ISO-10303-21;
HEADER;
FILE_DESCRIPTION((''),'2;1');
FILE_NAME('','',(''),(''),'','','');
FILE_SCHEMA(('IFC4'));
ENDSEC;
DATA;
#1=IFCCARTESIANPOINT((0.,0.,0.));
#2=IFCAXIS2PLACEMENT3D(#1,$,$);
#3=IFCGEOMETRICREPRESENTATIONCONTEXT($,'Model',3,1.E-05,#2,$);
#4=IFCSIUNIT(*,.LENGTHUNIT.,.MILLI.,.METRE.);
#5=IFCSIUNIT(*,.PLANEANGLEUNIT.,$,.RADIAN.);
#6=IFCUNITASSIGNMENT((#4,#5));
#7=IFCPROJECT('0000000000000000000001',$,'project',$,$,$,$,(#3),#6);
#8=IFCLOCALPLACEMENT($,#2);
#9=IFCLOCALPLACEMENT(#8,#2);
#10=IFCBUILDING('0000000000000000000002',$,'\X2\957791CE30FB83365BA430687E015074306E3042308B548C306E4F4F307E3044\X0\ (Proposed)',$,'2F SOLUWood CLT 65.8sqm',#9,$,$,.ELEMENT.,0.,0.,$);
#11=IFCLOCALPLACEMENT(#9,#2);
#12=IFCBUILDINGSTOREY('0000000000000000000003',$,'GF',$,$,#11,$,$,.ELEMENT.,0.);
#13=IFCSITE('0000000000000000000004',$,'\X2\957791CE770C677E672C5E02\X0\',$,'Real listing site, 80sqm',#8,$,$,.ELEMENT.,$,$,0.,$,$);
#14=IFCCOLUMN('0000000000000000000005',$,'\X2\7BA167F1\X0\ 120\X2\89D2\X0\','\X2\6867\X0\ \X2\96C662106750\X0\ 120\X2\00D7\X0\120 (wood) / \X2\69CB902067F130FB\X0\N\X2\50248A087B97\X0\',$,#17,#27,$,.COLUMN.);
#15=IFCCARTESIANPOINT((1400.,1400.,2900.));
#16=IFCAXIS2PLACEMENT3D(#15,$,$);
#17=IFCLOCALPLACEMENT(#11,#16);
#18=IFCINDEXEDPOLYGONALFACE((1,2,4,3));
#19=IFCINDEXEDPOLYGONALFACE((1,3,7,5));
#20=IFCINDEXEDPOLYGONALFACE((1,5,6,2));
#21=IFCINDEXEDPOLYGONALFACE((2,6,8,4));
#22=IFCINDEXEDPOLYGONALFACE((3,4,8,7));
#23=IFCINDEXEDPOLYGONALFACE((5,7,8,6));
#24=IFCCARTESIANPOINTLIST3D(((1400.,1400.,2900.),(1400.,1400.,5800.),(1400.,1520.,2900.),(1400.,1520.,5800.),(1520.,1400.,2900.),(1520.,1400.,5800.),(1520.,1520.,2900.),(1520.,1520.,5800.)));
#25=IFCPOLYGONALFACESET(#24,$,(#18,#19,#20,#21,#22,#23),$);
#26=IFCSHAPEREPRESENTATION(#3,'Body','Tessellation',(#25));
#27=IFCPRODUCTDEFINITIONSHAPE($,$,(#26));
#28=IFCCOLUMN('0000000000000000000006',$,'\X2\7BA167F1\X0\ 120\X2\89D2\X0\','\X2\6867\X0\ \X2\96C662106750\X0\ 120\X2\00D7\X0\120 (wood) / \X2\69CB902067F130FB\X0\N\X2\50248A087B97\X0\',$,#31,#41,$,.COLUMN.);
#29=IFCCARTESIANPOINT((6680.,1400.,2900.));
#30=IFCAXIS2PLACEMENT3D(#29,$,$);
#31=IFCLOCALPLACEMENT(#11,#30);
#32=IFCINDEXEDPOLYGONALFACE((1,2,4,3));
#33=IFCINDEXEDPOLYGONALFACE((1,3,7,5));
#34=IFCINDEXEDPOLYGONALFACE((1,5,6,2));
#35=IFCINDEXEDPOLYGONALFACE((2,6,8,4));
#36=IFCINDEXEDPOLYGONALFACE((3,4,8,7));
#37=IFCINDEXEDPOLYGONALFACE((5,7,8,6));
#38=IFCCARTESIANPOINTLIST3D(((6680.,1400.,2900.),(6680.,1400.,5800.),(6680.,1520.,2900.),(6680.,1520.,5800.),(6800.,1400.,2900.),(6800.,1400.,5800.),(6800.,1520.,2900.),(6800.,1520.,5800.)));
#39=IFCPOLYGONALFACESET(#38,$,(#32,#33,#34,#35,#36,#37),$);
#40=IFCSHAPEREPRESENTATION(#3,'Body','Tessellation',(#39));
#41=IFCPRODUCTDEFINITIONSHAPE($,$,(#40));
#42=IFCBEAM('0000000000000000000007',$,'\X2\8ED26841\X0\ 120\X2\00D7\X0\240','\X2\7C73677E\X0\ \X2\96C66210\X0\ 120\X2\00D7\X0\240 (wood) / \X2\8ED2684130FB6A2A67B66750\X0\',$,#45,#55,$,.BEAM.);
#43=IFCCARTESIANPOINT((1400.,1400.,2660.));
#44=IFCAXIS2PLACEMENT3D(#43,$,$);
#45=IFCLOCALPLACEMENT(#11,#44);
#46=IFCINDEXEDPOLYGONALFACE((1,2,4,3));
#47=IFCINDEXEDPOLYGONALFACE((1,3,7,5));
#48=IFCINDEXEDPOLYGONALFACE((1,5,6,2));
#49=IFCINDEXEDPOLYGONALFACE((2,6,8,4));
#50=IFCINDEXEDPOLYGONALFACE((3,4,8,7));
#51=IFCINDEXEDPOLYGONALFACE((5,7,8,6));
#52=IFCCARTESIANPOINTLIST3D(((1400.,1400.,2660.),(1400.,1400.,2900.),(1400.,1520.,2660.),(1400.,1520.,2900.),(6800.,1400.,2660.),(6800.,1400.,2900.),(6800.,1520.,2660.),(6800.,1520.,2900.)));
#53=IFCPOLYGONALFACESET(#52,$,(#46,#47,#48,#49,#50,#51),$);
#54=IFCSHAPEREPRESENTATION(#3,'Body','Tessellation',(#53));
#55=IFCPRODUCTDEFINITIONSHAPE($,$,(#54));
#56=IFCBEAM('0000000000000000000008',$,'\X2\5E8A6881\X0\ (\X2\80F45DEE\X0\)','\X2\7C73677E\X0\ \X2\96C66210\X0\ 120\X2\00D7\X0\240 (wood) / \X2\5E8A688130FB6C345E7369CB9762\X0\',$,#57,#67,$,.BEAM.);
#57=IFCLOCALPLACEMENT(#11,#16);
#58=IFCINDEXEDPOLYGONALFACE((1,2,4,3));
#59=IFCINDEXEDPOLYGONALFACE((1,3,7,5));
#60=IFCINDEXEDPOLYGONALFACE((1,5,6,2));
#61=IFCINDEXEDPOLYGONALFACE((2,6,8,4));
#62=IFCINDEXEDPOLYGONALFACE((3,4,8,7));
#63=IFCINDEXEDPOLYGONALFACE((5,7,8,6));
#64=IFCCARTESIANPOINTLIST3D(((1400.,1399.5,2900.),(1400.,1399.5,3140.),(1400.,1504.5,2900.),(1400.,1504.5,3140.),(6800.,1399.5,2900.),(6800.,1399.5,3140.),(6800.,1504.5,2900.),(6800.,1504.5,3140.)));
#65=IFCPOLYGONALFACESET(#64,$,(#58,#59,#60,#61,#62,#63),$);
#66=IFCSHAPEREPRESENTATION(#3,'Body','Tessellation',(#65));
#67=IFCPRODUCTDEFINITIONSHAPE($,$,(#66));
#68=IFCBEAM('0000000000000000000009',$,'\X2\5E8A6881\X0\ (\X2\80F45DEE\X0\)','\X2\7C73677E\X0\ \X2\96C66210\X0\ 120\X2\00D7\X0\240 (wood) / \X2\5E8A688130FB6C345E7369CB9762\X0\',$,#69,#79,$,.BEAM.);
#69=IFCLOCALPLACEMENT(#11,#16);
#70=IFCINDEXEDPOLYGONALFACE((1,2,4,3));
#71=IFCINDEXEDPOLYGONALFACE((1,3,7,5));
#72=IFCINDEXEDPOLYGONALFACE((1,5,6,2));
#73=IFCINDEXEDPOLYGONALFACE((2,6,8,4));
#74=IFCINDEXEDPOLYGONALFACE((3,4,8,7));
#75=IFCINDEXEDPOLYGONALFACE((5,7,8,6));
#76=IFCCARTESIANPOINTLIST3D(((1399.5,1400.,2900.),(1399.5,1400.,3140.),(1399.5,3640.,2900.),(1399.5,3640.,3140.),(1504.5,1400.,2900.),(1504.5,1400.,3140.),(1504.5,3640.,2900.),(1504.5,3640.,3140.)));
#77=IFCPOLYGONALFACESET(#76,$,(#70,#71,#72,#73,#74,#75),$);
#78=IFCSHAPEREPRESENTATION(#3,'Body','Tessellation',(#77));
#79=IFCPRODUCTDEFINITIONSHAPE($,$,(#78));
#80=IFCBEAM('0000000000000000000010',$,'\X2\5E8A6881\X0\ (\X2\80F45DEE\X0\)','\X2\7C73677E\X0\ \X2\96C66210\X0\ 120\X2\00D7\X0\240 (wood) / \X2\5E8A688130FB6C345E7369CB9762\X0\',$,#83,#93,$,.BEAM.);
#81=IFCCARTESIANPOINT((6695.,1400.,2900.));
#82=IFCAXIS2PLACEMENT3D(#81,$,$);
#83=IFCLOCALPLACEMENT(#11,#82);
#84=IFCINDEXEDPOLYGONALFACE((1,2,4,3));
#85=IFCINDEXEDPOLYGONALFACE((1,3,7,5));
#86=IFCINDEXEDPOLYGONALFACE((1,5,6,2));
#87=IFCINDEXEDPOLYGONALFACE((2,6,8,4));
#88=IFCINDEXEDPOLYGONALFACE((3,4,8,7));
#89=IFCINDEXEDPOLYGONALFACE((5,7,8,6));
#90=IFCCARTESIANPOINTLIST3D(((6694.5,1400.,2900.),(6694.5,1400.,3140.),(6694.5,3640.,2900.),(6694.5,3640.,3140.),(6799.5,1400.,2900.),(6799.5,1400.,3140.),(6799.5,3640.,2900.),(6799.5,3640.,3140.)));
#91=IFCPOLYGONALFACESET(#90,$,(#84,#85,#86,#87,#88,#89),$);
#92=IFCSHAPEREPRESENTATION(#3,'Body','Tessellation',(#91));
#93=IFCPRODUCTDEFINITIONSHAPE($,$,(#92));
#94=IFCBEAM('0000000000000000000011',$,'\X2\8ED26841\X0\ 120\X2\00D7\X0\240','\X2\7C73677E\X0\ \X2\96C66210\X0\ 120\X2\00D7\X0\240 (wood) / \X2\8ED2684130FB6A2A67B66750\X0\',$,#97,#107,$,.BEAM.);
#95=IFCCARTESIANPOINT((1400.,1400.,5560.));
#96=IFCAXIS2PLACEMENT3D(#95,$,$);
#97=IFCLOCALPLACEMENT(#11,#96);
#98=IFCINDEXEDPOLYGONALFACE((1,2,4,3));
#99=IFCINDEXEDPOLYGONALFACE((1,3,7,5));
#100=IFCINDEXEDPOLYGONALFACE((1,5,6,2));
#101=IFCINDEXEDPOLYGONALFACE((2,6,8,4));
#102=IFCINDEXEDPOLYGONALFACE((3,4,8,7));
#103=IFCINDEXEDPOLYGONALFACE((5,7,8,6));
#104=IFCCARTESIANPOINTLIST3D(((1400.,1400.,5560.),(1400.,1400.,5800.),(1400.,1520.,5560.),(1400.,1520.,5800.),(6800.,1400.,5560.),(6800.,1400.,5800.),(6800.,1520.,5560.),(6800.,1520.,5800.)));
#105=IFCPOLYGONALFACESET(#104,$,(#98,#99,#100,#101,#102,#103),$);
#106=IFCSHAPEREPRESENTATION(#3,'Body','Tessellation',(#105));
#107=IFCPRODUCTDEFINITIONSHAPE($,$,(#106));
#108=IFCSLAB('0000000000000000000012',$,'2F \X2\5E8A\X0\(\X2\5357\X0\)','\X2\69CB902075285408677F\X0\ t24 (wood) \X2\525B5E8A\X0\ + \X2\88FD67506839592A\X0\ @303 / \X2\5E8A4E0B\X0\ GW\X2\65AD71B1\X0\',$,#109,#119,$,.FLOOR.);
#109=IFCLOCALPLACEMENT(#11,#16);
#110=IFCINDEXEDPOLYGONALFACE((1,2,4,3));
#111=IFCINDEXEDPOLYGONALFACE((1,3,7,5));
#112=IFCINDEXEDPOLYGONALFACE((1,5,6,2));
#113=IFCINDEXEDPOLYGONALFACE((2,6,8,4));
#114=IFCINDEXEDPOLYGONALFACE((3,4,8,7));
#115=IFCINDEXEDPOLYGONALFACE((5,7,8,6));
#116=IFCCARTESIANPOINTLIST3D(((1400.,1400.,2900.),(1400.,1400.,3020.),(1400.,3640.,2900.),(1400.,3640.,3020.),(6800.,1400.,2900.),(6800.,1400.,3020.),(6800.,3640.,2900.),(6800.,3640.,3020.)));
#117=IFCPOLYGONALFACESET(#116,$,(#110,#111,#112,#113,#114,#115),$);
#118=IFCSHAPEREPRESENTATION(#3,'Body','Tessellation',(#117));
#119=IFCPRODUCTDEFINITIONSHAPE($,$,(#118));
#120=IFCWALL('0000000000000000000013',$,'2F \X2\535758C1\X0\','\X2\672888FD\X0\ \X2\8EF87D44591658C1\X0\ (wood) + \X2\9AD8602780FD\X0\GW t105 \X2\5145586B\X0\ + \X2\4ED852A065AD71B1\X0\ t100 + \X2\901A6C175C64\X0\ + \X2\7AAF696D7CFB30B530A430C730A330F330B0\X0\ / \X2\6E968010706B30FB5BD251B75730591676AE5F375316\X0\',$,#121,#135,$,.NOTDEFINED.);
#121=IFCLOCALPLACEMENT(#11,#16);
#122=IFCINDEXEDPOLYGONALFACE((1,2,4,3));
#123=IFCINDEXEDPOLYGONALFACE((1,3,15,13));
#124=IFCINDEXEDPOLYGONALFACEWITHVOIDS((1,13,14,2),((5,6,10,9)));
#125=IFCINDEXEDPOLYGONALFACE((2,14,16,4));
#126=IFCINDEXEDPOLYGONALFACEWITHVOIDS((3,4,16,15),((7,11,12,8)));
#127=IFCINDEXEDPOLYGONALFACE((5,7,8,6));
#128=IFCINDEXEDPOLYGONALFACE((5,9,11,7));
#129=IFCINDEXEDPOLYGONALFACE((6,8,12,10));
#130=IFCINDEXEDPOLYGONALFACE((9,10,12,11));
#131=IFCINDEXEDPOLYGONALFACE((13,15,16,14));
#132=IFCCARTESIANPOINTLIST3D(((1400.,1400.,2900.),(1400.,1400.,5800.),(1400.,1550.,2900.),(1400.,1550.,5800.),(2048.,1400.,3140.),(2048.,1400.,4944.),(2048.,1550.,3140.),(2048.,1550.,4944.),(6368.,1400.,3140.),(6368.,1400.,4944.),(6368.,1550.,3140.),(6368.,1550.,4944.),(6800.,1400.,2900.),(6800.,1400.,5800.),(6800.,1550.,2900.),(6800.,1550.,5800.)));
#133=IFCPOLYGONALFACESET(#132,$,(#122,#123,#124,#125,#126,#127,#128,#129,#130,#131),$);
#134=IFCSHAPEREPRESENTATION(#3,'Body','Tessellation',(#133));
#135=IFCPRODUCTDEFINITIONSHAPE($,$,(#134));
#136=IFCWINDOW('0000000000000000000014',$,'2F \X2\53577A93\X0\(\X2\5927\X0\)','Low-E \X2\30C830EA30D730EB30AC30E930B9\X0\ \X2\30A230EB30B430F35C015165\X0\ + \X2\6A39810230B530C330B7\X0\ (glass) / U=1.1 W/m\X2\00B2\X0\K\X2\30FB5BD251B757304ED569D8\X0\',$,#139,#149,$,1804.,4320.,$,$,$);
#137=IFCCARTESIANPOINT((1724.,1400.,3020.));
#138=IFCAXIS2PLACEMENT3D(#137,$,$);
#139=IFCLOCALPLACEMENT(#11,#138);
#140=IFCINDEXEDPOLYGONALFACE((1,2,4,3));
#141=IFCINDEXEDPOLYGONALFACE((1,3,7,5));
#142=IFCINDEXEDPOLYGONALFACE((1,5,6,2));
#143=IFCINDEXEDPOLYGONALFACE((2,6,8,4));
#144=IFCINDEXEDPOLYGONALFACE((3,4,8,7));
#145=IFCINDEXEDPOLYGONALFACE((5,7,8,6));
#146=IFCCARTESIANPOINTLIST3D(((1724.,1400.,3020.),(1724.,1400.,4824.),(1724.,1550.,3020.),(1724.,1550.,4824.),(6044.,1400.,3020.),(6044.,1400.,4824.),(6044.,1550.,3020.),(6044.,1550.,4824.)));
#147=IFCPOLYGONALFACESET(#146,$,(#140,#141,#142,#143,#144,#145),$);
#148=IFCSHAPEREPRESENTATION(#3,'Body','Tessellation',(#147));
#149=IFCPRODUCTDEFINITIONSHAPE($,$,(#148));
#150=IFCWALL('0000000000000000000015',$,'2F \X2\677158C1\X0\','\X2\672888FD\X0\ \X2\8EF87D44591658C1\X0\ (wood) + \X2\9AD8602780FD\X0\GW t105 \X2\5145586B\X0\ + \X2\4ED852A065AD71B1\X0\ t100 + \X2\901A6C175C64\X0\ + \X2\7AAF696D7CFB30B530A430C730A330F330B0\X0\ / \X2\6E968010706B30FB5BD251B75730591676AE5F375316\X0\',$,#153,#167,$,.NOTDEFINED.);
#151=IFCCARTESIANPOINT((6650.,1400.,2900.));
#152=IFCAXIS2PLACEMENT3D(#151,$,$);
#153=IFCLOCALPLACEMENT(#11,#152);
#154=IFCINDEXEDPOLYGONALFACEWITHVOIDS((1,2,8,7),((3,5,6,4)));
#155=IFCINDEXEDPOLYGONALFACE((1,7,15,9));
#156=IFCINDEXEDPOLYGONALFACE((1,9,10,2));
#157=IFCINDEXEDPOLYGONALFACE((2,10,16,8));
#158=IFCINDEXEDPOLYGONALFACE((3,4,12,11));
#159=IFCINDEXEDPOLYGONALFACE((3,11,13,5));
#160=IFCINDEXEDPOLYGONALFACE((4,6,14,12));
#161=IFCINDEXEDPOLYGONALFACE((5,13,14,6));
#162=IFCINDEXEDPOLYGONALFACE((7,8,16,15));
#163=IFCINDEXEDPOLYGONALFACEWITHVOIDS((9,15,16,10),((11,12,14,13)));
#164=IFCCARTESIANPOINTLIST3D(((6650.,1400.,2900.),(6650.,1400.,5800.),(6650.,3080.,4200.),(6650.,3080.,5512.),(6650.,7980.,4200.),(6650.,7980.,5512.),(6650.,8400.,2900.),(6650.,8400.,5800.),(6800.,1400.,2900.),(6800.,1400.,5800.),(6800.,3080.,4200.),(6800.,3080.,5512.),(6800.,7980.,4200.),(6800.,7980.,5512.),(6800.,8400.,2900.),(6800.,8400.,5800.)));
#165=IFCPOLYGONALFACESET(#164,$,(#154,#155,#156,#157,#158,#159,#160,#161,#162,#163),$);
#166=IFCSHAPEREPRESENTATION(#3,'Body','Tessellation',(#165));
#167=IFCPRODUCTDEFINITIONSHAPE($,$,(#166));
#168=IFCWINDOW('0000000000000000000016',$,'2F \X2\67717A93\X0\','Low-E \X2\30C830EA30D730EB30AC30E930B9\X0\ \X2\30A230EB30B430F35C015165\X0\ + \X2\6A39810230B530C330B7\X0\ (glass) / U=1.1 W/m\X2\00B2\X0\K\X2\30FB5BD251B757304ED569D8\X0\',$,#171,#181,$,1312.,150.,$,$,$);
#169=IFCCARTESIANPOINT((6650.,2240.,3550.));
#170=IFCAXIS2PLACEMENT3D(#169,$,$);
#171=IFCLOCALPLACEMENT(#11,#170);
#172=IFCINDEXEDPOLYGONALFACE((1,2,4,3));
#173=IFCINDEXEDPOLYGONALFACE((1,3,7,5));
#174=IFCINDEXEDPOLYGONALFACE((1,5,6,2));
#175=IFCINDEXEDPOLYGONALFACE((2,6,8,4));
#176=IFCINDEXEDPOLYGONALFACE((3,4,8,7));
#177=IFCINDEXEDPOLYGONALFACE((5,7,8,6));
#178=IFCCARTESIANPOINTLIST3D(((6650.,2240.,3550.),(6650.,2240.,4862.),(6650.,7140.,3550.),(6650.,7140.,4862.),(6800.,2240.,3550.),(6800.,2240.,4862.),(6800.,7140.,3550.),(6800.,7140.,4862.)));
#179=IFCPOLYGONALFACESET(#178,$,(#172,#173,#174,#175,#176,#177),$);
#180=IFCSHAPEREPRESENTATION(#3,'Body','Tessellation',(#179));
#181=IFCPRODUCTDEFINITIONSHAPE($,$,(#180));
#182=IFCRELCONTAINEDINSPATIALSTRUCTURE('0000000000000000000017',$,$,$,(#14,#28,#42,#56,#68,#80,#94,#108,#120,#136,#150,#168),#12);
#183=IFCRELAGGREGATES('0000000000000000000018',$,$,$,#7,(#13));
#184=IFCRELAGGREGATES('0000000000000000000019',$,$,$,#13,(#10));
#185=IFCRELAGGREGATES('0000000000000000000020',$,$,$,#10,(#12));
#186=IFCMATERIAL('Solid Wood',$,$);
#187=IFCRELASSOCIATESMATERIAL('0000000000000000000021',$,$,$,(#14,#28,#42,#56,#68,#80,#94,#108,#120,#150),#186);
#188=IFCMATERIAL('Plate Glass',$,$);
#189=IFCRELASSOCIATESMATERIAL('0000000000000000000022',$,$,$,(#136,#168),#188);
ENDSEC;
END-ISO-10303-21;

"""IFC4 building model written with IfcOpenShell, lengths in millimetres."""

from ifc_helpers import new_model, si_unit, frame, frame_2d, origin, place, context, project, spatial, rectangle, extrude, material, element, fill, save


model = new_model("IFC4")

# Units and contexts
model_context = context("Model", 3, precision=1e-05, world=origin())
ifc_project = project(units=[si_unit("LENGTHUNIT", "METRE", prefix="MILLI"), si_unit("PLANEANGLEUNIT", "RADIAN")], contexts=[model_context])

# Site, building, storey
site_placement = place(None, origin())
site = spatial("IfcSite", under=ifc_project, at=site_placement, Name="長野県松本市", ObjectType="Real listing site, 80sqm", CompositionType="ELEMENT", RefElevation=0.0)
building_placement = place(site_placement, origin())
building = spatial("IfcBuilding", under=site, at=building_placement, Name="長野・茶室と縁側のある和の住まい (Proposed)", ObjectType="2F SOLUWood CLT 65.8sqm", CompositionType="ELEMENT", ElevationOfRefHeight=0.0, ElevationOfTerrain=0.0)
storey_placement = place(building_placement, origin())
storey = spatial("IfcBuildingStorey", under=building, at=storey_placement, Name="GF", CompositionType="ELEMENT", Elevation=0.0)

# Columns
ifc_material_1 = material(Name="Solid Wood")
column_1_placement = place(storey_placement, frame((1400.0, 1400.0, 2900.0)))
element("IfcColumn", 1, at=column_1_placement, inside=storey, material=ifc_material_1, Name="管柱 120角", Description="桧 集成材 120×120 (wood) / 構造柱・N値計算", PredefinedType="COLUMN", context=model_context, shape_type="SweptSolid", body=[
    extrude(rectangle(XDim=120.0, YDim=120.0, at=frame_2d((60.0, 60.0))), frame((1400.0, 1400.0, 2900.0)), (0.0, 0.0, 1.0), 2900.0),
])
column_2_placement = place(storey_placement, frame((6680.0, 1400.0, 2900.0)))
element("IfcColumn", 2, at=column_2_placement, inside=storey, material=ifc_material_1, Name="管柱 120角", Description="桧 集成材 120×120 (wood) / 構造柱・N値計算", PredefinedType="COLUMN", context=model_context, shape_type="SweptSolid", body=[
    extrude(rectangle(XDim=120.0, YDim=120.0, at=frame_2d((60.0, 60.0))), frame((6680.0, 1400.0, 2900.0)), (0.0, 0.0, 1.0), 2900.0),
])

# Beams
beam_1_placement = place(storey_placement, frame((1400.0, 1400.0, 2660.0)))
element("IfcBeam", 3, at=beam_1_placement, inside=storey, material=ifc_material_1, Name="軒桁 120×240", Description="米松 集成 120×240 (wood) / 軒桁・横架材", PredefinedType="BEAM", context=model_context, shape_type="SweptSolid", body=[
    extrude(rectangle(XDim=5400.0, YDim=120.0, at=frame_2d((2700.0, 60.0))), frame((1400.0, 1400.0, 2660.0)), (0.0, 0.0, 1.0), 240.0),
])
beam_2_placement = place(storey_placement, frame((1400.0, 1400.0, 2900.0)))
element("IfcBeam", 4, at=beam_2_placement, inside=storey, material=ifc_material_1, Name="床梁 (胴差)", Description="米松 集成 120×240 (wood) / 床梁・水平構面", PredefinedType="BEAM", context=model_context, shape_type="SweptSolid", body=[
    extrude(rectangle(XDim=5400.0, YDim=105.0, at=frame_2d((2700.0, 52.0))), frame((1400.0, 1400.0, 2900.0)), (0.0, 0.0, 1.0), 240.0),
])
beam_3_placement = place(storey_placement, frame((1400.0, 1400.0, 2900.0)))
element("IfcBeam", 5, at=beam_3_placement, inside=storey, material=ifc_material_1, Name="床梁 (胴差)", Description="米松 集成 120×240 (wood) / 床梁・水平構面", PredefinedType="BEAM", context=model_context, shape_type="SweptSolid", body=[
    extrude(rectangle(XDim=105.0, YDim=2240.0, at=frame_2d((52.0, 1120.0))), frame((1400.0, 1400.0, 2900.0)), (0.0, 0.0, 1.0), 240.0),
])
beam_4_placement = place(storey_placement, frame((6695.0, 1400.0, 2900.0)))
element("IfcBeam", 6, at=beam_4_placement, inside=storey, material=ifc_material_1, Name="床梁 (胴差)", Description="米松 集成 120×240 (wood) / 床梁・水平構面", PredefinedType="BEAM", context=model_context, shape_type="SweptSolid", body=[
    extrude(rectangle(XDim=105.0, YDim=2240.0, at=frame_2d((52.0, 1120.0))), frame((6695.0, 1400.0, 2900.0)), (0.0, 0.0, 1.0), 240.0),
])
beam_5_placement = place(storey_placement, frame((1400.0, 1400.0, 5560.0)))
element("IfcBeam", 7, at=beam_5_placement, inside=storey, material=ifc_material_1, Name="軒桁 120×240", Description="米松 集成 120×240 (wood) / 軒桁・横架材", PredefinedType="BEAM", context=model_context, shape_type="SweptSolid", body=[
    extrude(rectangle(XDim=5400.0, YDim=120.0, at=frame_2d((2700.0, 60.0))), frame((1400.0, 1400.0, 5560.0)), (0.0, 0.0, 1.0), 240.0),
])

# Slab
slab_placement = place(storey_placement, frame((1400.0, 1400.0, 2900.0)))
element("IfcSlab", 8, at=slab_placement, inside=storey, material=ifc_material_1, Name="2F 床(南)", Description="構造用合板 t24 (wood) 剛床 + 製材根太 @303 / 床下 GW断熱", PredefinedType="FLOOR", context=model_context, shape_type="SweptSolid", body=[
    extrude(rectangle(XDim=5400.0, YDim=2240.0, at=frame_2d((2700.0, 1120.0))), frame((1400.0, 1400.0, 2900.0)), (0.0, 0.0, 1.0), 120.0),
])

# Walls, openings, windows
wall_1_placement = place(storey_placement, frame((1400.0, 1400.0, 2900.0)))
wall_1 = element("IfcWall", 9, at=wall_1_placement, inside=storey, material=ifc_material_1, Name="2F 南壁", Description="木製 軸組外壁 (wood) + 高性能GW t105 充填 + 付加断熱 t100 + 通気層 + 窯業系サイディング / 準耐火・寒冷地外皮強化", PredefinedType="NOTDEFINED", context=model_context, shape_type="SweptSolid", body=[
    extrude(rectangle(XDim=5400.0, YDim=150.0, at=frame_2d((2700.0, 75.0))), frame((1400.0, 1400.0, 2900.0)), (0.0, 0.0, 1.0), 2900.0),
])
opening_1_placement = place(storey_placement, frame((1724.0, 1400.0, 3020.0)))
opening_1 = element("IfcOpeningElement", 10, at=opening_1_placement, cuts=wall_1, PredefinedType="NOTDEFINED", context=model_context, shape_type="SweptSolid", body=[
    extrude(rectangle(XDim=4320.0, YDim=150.0, at=frame_2d((2160.0, 75.0))), frame((1724.0, 1400.0, 3020.0)), (0.0, 0.0, 1.0), 1804.0),
])
ifc_material_2 = material(Name="Plate Glass")
window_1_placement = place(storey_placement, frame((1724.0, 1400.0, 3020.0)))
window_1 = element("IfcWindow", 11, at=window_1_placement, inside=storey, material=ifc_material_2, Name="2F 南窓(大)", Description="Low-E トリプルガラス アルゴン封入 + 樹脂サッシ (glass) / U=1.1 W/m²K・寒冷地仕様", OverallHeight=1804.0, OverallWidth=4320.0, context=model_context, shape_type="SweptSolid", body=[
    extrude(rectangle(XDim=4320.0, YDim=150.0, at=frame_2d((2160.0, 75.0))), frame((1724.0, 1400.0, 3020.0)), (0.0, 0.0, 1.0), 1804.0),
])
fill(opening_1, window_1)
wall_2_placement = place(storey_placement, frame((6650.0, 1400.0, 2900.0)))
wall_2 = element("IfcWall", 12, at=wall_2_placement, inside=storey, material=ifc_material_1, Name="2F 東壁", Description="木製 軸組外壁 (wood) + 高性能GW t105 充填 + 付加断熱 t100 + 通気層 + 窯業系サイディング / 準耐火・寒冷地外皮強化", PredefinedType="NOTDEFINED", context=model_context, shape_type="SweptSolid", body=[
    extrude(rectangle(XDim=150.0, YDim=7000.0, at=frame_2d((75.0, 3500.0))), frame((6650.0, 1400.0, 2900.0)), (0.0, 0.0, 1.0), 2900.0),
])
opening_2_placement = place(storey_placement, frame((6650.0, 2240.0, 3550.0)))
opening_2 = element("IfcOpeningElement", 13, at=opening_2_placement, cuts=wall_2, PredefinedType="NOTDEFINED", context=model_context, shape_type="SweptSolid", body=[
    extrude(rectangle(XDim=150.0, YDim=4900.0, at=frame_2d((75.0, 2450.0))), frame((6650.0, 2240.0, 3550.0)), (0.0, 0.0, 1.0), 1312.0),
])
window_2_placement = place(storey_placement, frame((6650.0, 2240.0, 3550.0)))
window_2 = element("IfcWindow", 14, at=window_2_placement, inside=storey, material=ifc_material_2, Name="2F 東窓", Description="Low-E トリプルガラス アルゴン封入 + 樹脂サッシ (glass) / U=1.1 W/m²K・寒冷地仕様", OverallHeight=1312.0, OverallWidth=150.0, context=model_context, shape_type="SweptSolid", body=[
    extrude(rectangle(XDim=150.0, YDim=4900.0, at=frame_2d((75.0, 2450.0))), frame((6650.0, 2240.0, 3550.0)), (0.0, 0.0, 1.0), 1312.0),
])
fill(opening_2, window_2)

save(model, "model.ifc")
